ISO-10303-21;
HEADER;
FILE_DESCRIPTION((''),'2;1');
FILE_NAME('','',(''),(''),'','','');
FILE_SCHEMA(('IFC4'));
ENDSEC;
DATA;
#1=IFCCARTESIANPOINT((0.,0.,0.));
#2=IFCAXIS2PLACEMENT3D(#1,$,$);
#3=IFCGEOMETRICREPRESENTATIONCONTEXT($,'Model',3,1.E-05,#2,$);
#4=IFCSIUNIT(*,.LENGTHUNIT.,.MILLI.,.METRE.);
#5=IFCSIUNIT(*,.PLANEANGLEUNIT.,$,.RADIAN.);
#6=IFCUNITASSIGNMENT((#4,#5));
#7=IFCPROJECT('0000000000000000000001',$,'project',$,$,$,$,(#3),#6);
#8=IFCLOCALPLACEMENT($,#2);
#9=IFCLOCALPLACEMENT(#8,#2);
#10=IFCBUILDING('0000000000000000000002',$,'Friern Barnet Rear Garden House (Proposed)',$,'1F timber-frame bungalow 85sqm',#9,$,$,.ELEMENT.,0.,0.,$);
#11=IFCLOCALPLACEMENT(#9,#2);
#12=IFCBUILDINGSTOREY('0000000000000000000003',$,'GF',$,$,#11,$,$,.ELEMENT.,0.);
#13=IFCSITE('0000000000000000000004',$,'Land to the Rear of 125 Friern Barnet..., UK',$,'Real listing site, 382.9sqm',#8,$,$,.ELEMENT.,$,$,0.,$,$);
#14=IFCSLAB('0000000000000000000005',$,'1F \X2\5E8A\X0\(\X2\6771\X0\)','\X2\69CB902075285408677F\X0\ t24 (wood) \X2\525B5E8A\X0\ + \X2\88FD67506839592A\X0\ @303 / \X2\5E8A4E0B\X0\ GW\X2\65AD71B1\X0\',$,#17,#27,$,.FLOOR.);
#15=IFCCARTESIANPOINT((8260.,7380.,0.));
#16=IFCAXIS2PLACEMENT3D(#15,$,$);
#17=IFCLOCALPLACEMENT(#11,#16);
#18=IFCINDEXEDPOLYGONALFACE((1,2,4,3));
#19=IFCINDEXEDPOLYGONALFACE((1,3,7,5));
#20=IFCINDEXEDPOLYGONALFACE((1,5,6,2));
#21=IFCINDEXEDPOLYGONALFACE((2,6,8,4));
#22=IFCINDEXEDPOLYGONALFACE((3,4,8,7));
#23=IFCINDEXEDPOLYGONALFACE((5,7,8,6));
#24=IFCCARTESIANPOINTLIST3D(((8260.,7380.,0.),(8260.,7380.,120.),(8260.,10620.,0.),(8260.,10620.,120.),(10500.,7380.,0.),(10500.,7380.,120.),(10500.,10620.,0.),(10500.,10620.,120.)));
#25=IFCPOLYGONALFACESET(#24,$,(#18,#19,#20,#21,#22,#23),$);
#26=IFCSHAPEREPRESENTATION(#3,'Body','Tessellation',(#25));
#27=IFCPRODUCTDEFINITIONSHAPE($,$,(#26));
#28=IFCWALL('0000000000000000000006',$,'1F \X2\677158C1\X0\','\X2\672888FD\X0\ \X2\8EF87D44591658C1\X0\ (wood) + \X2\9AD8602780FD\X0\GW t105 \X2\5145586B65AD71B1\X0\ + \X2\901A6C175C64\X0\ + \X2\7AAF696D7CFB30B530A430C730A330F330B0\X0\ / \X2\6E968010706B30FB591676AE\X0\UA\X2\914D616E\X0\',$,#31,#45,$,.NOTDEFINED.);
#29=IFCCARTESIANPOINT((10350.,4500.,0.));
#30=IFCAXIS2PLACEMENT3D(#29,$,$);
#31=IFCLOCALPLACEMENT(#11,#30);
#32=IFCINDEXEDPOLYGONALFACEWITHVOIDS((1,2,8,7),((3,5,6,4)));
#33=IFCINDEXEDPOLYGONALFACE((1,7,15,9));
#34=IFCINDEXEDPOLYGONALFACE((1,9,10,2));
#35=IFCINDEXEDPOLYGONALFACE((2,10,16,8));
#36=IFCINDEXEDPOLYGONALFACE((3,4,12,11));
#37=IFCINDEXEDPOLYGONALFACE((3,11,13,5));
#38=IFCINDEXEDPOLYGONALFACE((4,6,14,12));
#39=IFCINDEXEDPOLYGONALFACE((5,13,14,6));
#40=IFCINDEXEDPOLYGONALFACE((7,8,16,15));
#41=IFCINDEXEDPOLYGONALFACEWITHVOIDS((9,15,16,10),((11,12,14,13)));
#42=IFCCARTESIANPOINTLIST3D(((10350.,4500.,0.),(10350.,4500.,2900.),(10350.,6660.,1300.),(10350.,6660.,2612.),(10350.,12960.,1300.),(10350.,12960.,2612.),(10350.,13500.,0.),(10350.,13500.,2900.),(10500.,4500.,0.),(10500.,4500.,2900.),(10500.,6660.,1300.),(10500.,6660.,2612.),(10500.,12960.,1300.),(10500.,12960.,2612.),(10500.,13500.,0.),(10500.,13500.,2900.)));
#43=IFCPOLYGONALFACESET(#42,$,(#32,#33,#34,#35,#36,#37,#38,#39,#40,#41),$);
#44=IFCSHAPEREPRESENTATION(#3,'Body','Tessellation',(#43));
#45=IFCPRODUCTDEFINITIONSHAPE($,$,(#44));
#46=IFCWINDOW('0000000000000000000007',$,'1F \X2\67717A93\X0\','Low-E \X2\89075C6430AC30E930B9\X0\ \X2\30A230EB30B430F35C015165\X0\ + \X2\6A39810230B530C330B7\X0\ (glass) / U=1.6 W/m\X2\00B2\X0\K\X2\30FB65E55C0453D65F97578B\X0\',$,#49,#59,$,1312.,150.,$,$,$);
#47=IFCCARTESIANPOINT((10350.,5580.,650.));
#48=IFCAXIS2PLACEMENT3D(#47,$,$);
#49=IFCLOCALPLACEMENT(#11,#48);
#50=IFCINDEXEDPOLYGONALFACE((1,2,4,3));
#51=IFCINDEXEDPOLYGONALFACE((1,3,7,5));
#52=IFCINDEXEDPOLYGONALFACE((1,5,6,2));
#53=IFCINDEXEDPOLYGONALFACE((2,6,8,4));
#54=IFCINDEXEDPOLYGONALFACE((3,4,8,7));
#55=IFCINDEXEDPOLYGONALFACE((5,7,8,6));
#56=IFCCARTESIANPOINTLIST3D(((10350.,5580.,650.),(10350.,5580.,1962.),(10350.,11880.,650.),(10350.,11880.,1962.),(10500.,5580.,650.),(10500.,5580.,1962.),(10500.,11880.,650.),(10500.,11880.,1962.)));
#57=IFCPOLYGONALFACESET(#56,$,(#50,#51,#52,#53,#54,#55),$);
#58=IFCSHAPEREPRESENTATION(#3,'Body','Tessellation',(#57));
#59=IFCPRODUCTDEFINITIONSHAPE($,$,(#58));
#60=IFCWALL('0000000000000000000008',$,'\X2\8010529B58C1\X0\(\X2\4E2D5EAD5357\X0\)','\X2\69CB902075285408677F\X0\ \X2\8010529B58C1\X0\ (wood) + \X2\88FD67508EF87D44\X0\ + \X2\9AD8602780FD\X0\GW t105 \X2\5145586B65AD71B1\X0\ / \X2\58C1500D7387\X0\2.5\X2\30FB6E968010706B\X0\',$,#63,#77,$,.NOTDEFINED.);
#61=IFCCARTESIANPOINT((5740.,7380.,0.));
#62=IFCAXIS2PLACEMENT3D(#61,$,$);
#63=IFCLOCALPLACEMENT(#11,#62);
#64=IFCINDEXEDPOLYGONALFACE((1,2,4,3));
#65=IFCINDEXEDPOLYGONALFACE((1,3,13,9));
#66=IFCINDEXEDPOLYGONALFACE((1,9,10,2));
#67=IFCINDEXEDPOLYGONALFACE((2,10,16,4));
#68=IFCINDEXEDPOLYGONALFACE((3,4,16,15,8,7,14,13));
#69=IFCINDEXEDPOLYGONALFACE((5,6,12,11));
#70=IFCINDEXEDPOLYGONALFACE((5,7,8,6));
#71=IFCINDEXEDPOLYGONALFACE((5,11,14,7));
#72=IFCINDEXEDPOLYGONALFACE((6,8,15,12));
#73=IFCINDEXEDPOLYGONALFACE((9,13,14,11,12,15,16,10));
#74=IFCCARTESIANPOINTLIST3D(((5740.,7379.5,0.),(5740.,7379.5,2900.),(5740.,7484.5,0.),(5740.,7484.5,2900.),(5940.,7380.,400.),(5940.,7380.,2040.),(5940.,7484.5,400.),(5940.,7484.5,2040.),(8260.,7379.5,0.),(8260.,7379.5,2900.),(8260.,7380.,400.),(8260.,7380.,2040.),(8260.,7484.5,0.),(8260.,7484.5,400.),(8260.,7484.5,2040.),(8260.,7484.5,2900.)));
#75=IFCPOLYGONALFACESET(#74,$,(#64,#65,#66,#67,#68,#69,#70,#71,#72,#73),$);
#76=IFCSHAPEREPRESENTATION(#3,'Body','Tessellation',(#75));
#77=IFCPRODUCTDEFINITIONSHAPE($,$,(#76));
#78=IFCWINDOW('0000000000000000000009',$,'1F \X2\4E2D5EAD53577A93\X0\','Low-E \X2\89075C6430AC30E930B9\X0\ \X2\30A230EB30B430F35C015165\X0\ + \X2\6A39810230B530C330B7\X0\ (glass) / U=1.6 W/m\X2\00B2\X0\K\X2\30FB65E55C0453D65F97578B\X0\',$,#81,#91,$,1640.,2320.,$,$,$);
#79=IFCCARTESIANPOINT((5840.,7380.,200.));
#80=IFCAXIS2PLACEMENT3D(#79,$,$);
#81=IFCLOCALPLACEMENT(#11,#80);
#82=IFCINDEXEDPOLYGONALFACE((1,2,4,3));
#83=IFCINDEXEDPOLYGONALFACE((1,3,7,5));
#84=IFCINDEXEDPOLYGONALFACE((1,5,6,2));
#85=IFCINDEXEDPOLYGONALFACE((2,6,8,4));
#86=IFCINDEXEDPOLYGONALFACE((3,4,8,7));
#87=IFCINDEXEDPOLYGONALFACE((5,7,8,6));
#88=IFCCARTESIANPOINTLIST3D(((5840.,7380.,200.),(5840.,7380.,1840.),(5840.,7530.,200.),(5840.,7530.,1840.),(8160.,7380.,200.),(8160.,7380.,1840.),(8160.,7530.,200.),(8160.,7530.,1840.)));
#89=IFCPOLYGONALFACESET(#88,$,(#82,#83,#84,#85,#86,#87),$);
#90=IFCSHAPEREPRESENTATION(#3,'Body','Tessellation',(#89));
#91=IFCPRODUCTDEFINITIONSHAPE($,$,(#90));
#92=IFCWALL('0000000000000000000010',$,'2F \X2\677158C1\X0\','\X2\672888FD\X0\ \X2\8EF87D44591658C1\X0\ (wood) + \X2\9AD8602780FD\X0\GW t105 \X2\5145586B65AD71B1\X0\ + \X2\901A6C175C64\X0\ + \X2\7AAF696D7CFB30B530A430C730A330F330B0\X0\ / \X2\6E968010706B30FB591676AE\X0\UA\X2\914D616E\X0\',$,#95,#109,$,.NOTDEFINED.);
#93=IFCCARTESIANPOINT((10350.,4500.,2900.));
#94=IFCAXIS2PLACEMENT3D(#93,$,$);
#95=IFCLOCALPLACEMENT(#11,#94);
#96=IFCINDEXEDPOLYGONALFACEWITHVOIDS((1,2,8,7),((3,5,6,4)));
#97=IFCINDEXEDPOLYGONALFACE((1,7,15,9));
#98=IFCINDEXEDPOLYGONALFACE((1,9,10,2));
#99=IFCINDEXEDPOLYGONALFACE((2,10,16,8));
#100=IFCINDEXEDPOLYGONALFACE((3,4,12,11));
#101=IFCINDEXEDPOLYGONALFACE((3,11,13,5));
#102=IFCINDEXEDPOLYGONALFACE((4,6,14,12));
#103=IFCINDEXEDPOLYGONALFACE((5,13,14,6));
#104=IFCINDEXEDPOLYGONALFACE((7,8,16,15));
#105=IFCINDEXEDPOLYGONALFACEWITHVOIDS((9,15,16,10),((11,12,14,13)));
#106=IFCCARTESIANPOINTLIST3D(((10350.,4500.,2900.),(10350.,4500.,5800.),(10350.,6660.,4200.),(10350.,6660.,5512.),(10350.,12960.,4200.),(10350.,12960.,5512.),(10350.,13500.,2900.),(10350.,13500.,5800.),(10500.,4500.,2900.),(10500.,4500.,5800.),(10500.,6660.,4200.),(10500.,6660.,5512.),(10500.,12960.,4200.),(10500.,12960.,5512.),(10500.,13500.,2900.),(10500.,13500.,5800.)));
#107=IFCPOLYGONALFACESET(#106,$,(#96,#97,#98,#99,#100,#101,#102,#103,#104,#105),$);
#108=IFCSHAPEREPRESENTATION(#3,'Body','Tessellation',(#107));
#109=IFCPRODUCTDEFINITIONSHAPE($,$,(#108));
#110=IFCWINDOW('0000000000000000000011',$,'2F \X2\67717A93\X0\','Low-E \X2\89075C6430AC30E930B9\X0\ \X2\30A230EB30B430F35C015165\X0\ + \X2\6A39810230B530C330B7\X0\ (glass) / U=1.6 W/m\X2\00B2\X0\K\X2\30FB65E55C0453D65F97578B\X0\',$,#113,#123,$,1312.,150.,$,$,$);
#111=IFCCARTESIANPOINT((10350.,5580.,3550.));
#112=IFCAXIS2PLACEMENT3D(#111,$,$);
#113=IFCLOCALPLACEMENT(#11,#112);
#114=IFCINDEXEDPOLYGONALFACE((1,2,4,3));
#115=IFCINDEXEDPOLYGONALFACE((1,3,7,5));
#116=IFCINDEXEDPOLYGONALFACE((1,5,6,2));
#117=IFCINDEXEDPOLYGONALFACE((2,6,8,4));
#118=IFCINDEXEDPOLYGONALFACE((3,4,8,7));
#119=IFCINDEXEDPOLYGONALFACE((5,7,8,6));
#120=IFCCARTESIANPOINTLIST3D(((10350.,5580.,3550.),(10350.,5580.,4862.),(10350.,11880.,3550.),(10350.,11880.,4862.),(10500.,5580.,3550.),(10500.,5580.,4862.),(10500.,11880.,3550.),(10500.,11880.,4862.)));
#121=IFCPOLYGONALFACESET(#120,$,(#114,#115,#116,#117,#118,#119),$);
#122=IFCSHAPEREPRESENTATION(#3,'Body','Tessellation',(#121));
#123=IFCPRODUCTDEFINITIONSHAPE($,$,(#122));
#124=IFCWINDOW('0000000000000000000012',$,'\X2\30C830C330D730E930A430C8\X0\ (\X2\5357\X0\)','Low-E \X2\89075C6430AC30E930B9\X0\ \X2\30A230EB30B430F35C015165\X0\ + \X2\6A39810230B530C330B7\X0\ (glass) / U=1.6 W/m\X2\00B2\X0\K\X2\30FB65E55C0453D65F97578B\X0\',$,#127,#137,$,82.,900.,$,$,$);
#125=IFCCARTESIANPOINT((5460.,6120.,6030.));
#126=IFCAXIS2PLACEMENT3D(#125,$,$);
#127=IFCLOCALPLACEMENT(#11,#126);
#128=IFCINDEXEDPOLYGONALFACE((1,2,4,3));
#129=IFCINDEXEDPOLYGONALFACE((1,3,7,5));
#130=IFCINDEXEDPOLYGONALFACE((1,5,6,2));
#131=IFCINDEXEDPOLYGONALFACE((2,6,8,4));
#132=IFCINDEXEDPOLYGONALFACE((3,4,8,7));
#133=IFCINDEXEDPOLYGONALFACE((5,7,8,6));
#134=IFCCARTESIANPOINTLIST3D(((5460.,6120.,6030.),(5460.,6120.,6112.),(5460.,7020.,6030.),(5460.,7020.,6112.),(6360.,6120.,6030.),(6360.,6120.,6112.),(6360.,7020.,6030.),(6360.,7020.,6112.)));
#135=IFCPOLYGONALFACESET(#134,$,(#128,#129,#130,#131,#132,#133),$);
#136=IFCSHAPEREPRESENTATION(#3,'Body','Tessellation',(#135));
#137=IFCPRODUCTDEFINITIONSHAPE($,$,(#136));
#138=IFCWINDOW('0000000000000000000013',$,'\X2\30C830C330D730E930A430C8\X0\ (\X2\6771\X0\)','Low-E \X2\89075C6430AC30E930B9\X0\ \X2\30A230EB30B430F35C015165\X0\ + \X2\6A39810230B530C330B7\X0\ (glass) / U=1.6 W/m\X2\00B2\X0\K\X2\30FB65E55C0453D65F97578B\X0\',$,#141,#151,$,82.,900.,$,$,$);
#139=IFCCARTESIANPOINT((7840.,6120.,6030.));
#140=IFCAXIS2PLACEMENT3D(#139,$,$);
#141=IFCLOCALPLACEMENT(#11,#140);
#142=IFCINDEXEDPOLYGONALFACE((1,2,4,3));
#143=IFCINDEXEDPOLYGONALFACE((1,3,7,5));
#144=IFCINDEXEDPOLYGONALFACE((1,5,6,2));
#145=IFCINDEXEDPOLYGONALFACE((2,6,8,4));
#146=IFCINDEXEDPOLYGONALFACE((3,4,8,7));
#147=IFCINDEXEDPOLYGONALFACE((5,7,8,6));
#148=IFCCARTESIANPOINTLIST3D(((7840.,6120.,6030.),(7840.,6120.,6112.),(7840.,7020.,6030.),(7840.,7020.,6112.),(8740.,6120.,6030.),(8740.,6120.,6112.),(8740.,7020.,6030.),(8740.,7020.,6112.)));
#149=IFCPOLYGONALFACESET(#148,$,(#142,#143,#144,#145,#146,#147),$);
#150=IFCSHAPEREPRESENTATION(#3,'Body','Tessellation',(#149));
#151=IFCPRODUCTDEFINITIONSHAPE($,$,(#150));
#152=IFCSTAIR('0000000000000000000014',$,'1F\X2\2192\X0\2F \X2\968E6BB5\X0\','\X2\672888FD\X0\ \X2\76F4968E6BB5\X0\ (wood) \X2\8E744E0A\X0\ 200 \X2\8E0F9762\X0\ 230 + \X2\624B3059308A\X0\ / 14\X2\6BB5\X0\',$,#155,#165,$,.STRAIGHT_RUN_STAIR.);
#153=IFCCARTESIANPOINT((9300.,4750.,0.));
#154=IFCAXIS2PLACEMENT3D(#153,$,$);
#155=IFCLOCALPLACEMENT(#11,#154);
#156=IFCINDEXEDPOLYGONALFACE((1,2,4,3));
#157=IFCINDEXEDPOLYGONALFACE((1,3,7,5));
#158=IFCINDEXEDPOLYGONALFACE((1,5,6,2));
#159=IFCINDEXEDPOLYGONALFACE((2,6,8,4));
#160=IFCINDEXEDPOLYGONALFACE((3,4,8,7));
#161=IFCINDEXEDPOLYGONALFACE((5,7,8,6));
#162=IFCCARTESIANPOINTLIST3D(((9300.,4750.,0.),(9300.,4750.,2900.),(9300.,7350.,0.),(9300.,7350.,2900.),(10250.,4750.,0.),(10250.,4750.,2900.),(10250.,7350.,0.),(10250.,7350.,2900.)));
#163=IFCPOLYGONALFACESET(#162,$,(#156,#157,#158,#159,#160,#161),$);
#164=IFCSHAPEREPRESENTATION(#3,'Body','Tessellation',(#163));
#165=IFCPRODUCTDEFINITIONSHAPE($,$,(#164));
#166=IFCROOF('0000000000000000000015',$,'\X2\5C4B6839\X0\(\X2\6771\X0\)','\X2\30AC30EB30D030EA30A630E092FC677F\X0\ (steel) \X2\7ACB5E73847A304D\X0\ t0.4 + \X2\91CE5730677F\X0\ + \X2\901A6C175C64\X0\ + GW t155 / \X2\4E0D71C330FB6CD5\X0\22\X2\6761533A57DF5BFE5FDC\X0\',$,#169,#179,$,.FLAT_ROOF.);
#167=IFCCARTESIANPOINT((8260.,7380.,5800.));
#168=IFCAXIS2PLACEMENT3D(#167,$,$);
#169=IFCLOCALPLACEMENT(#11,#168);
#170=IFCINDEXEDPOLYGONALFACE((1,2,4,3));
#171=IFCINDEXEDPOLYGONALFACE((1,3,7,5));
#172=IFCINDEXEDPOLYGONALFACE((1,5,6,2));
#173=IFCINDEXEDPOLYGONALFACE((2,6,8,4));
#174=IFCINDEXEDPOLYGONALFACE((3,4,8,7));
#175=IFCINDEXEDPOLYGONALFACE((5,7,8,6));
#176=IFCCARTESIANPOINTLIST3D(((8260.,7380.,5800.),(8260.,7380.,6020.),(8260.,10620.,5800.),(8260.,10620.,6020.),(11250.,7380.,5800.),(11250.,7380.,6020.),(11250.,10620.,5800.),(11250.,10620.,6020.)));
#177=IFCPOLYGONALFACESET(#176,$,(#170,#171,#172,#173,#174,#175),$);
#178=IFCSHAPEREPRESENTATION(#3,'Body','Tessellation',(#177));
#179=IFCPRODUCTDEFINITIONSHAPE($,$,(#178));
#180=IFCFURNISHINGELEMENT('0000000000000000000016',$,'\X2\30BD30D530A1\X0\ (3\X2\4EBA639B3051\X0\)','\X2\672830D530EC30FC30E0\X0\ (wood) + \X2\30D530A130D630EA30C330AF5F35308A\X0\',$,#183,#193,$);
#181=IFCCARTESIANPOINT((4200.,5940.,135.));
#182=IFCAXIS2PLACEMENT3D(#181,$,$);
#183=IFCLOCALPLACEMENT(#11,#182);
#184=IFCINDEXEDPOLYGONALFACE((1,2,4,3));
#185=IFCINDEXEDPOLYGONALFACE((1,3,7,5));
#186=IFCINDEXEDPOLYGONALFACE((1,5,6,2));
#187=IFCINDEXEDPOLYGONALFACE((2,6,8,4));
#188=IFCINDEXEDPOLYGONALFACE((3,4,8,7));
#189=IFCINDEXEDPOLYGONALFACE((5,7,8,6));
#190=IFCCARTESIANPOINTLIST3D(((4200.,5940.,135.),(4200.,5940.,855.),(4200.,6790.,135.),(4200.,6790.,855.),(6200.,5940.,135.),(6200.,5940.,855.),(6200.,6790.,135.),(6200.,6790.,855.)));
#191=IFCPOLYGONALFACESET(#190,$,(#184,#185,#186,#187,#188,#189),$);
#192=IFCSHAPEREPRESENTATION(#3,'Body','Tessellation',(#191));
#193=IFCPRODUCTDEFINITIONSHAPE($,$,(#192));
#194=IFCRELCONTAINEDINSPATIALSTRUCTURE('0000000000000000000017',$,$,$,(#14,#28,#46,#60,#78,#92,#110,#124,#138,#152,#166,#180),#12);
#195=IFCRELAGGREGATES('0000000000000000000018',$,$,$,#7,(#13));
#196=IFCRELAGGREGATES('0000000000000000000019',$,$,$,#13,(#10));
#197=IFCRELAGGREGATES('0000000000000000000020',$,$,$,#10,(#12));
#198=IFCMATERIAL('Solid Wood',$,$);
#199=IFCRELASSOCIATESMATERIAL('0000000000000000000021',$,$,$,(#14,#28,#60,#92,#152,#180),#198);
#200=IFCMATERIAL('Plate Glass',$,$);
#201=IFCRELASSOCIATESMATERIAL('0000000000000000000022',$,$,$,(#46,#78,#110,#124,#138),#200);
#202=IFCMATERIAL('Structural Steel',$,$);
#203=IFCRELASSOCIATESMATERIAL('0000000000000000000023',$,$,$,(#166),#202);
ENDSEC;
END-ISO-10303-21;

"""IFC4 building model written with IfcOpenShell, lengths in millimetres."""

from ifc_helpers import new_model, si_unit, frame, frame_2d, origin, place, context, project, spatial, rectangle, extrude, material, element, fill, save


model = new_model("IFC4")

# Units and contexts
model_context = context("Model", 3, precision=1e-05, world=origin())
ifc_project = project(units=[si_unit("LENGTHUNIT", "METRE", prefix="MILLI"), si_unit("PLANEANGLEUNIT", "RADIAN")], contexts=[model_context])

# Site, building, storey
site_placement = place(None, origin())
site = spatial("IfcSite", under=ifc_project, at=site_placement, Name="Land to the Rear of 125 Friern Barnet..., UK", ObjectType="Real listing site, 382.9sqm", CompositionType="ELEMENT", RefElevation=0.0)
building_placement = place(site_placement, origin())
building = spatial("IfcBuilding", under=site, at=building_placement, Name="Friern Barnet Rear Garden House (Proposed)", ObjectType="1F timber-frame bungalow 85sqm", CompositionType="ELEMENT", ElevationOfRefHeight=0.0, ElevationOfTerrain=0.0)
storey_placement = place(building_placement, origin())
storey = spatial("IfcBuildingStorey", under=building, at=storey_placement, Name="GF", CompositionType="ELEMENT", Elevation=0.0)

# Slab
ifc_material_1 = material(Name="Solid Wood")
slab_placement = place(storey_placement, frame((8260.0, 7380.0, 0.0)))
element("IfcSlab", 1, at=slab_placement, inside=storey, material=ifc_material_1, Name="1F 床(東)", Description="構造用合板 t24 (wood) 剛床 + 製材根太 @303 / 床下 GW断熱", PredefinedType="FLOOR", context=model_context, shape_type="SweptSolid", body=[
    extrude(rectangle(XDim=2240.0, YDim=3240.0, at=frame_2d((1120.0, 1620.0))), frame((8260.0, 7380.0, 0.0)), (0.0, 0.0, 1.0), 120.0),
])

# Walls, openings, windows
wall_1_placement = place(storey_placement, frame((10350.0, 4500.0, 0.0)))
wall_1 = element("IfcWall", 2, at=wall_1_placement, inside=storey, material=ifc_material_1, Name="1F 東壁", Description="木製 軸組外壁 (wood) + 高性能GW t105 充填断熱 + 通気層 + 窯業系サイディング / 準耐火・外皮UA配慮", PredefinedType="NOTDEFINED", context=model_context, shape_type="SweptSolid", body=[
    extrude(rectangle(XDim=150.0, YDim=9000.0, at=frame_2d((75.0, 4500.0))), frame((10350.0, 4500.0, 0.0)), (0.0, 0.0, 1.0), 2900.0),
])
opening_1_placement = place(storey_placement, frame((10350.0, 5580.0, 650.0)))
opening_1 = element("IfcOpeningElement", 3, at=opening_1_placement, cuts=wall_1, PredefinedType="NOTDEFINED", context=model_context, shape_type="SweptSolid", body=[
    extrude(rectangle(XDim=150.0, YDim=6300.0, at=frame_2d((75.0, 3150.0))), frame((10350.0, 5580.0, 650.0)), (0.0, 0.0, 1.0), 1312.0),
])
ifc_material_2 = material(Name="Plate Glass")
window_1_placement = place(storey_placement, frame((10350.0, 5580.0, 650.0)))
window_1 = element("IfcWindow", 4, at=window_1_placement, inside=storey, material=ifc_material_2, Name="1F 東窓", Description="Low-E 複層ガラス アルゴン封入 + 樹脂サッシ (glass) / U=1.6 W/m²K・日射取得型", OverallHeight=1312.0, OverallWidth=150.0, context=model_context, shape_type="SweptSolid", body=[
    extrude(rectangle(XDim=150.0, YDim=6300.0, at=frame_2d((75.0, 3150.0))), frame((10350.0, 5580.0, 650.0)), (0.0, 0.0, 1.0), 1312.0),
])
fill(opening_1, window_1)
wall_2_placement = place(storey_placement, frame((5740.0, 7380.0, 0.0)))
wall_2 = element("IfcWall", 5, at=wall_2_placement, inside=storey, material=ifc_material_1, Name="耐力壁(中庭南)", Description="構造用合板 耐力壁 (wood) + 製材軸組 + 高性能GW t105 充填断熱 / 壁倍率2.5・準耐火", PredefinedType="NOTDEFINED", context=model_context, shape_type="SweptSolid", body=[
    extrude(rectangle(XDim=2520.0, YDim=105.0, at=frame_2d((1260.0, 52.0))), frame((5740.0, 7380.0, 0.0)), (0.0, 0.0, 1.0), 2900.0),
])
opening_2_placement = place(storey_placement, frame((5840.0, 7380.0, 200.0)))
opening_2 = element("IfcOpeningElement", 6, at=opening_2_placement, cuts=wall_2, PredefinedType="NOTDEFINED", context=model_context, shape_type="SweptSolid", body=[
    extrude(rectangle(XDim=2320.0, YDim=150.0, at=frame_2d((1160.0, 75.0))), frame((5840.0, 7380.0, 200.0)), (0.0, 0.0, 1.0), 1640.0),
])
window_2_placement = place(storey_placement, frame((5840.0, 7380.0, 200.0)))
window_2 = element("IfcWindow", 7, at=window_2_placement, inside=storey, material=ifc_material_2, Name="1F 中庭南窓", Description="Low-E 複層ガラス アルゴン封入 + 樹脂サッシ (glass) / U=1.6 W/m²K・日射取得型", OverallHeight=1640.0, OverallWidth=2320.0, context=model_context, shape_type="SweptSolid", body=[
    extrude(rectangle(XDim=2320.0, YDim=150.0, at=frame_2d((1160.0, 75.0))), frame((5840.0, 7380.0, 200.0)), (0.0, 0.0, 1.0), 1640.0),
])
fill(opening_2, window_2)

# Wall, opening, window
wall_3_placement = place(storey_placement, frame((10350.0, 4500.0, 2900.0)))
wall_3 = element("IfcWall", 8, at=wall_3_placement, inside=storey, material=ifc_material_1, Name="2F 東壁", Description="木製 軸組外壁 (wood) + 高性能GW t105 充填断熱 + 通気層 + 窯業系サイディング / 準耐火・外皮UA配慮", PredefinedType="NOTDEFINED", context=model_context, shape_type="SweptSolid", body=[
    extrude(rectangle(XDim=150.0, YDim=9000.0, at=frame_2d((75.0, 4500.0))), frame((10350.0, 4500.0, 2900.0)), (0.0, 0.0, 1.0), 2900.0),
])
opening_3_placement = place(storey_placement, frame((10350.0, 5580.0, 3550.0)))
opening_3 = element("IfcOpeningElement", 9, at=opening_3_placement, cuts=wall_3, PredefinedType="NOTDEFINED", context=model_context, shape_type="SweptSolid", body=[
    extrude(rectangle(XDim=150.0, YDim=6300.0, at=frame_2d((75.0, 3150.0))), frame((10350.0, 5580.0, 3550.0)), (0.0, 0.0, 1.0), 1312.0),
])
window_3_placement = place(storey_placement, frame((10350.0, 5580.0, 3550.0)))
window_3 = element("IfcWindow", 10, at=window_3_placement, inside=storey, material=ifc_material_2, Name="2F 東窓", Description="Low-E 複層ガラス アルゴン封入 + 樹脂サッシ (glass) / U=1.6 W/m²K・日射取得型", OverallHeight=1312.0, OverallWidth=150.0, context=model_context, shape_type="SweptSolid", body=[
    extrude(rectangle(XDim=150.0, YDim=6300.0, at=frame_2d((75.0, 3150.0))), frame((10350.0, 5580.0, 3550.0)), (0.0, 0.0, 1.0), 1312.0),
])
fill(opening_3, window_3)

# Windows
window_4_placement = place(storey_placement, frame((5460.0, 6120.0, 6030.0)))
element("IfcWindow", 11, at=window_4_placement, inside=storey, material=ifc_material_2, Name="トップライト (南)", Description="Low-E 複層ガラス アルゴン封入 + 樹脂サッシ (glass) / U=1.6 W/m²K・日射取得型", OverallHeight=82.0, OverallWidth=900.0, context=model_context, shape_type="SweptSolid", body=[
    extrude(rectangle(XDim=900.0, YDim=900.0, at=frame_2d((450.0, 450.0))), frame((5460.0, 6120.0, 6030.0)), (0.0, 0.0, 1.0), 82.0),
])
window_5_placement = place(storey_placement, frame((7840.0, 6120.0, 6030.0)))
element("IfcWindow", 12, at=window_5_placement, inside=storey, material=ifc_material_2, Name="トップライト (東)", Description="Low-E 複層ガラス アルゴン封入 + 樹脂サッシ (glass) / U=1.6 W/m²K・日射取得型", OverallHeight=82.0, OverallWidth=900.0, context=model_context, shape_type="SweptSolid", body=[
    extrude(rectangle(XDim=900.0, YDim=900.0, at=frame_2d((450.0, 450.0))), frame((7840.0, 6120.0, 6030.0)), (0.0, 0.0, 1.0), 82.0),
])

# Stair
stair_placement = place(storey_placement, frame((9300.0, 4750.0, 0.0)))
element("IfcStair", 13, at=stair_placement, inside=storey, material=ifc_material_1, Name="1F→2F 階段", Description="木製 直階段 (wood) 蹴上 200 踏面 230 + 手すり / 14段", PredefinedType="STRAIGHT_RUN_STAIR", context=model_context, shape_type="SweptSolid", body=[
    extrude(rectangle(XDim=950.0, YDim=2600.0, at=frame_2d((475.0, 1300.0))), frame((9300.0, 4750.0, 0.0)), (0.0, 0.0, 1.0), 2900.0),
])

# Roof
ifc_material_3 = material(Name="Structural Steel")
roof_placement = place(storey_placement, frame((8260.0, 7380.0, 5800.0)))
element("IfcRoof", 14, at=roof_placement, inside=storey, material=ifc_material_3, Name="屋根(東)", Description="ガルバリウム鋼板 (steel) 立平葺き t0.4 + 野地板 + 通気層 + GW t155 / 不燃・法22条区域対応", PredefinedType="FLAT_ROOF", context=model_context, shape_type="SweptSolid", body=[
    extrude(rectangle(XDim=2990.0, YDim=3240.0, at=frame_2d((1495.0, 1620.0))), frame((8260.0, 7380.0, 5800.0)), (0.0, 0.0, 1.0), 220.0),
])

# Furnishing element
furnishing_1_placement = place(storey_placement, frame((4200.0, 5940.0, 135.0)))
element("IfcFurnishingElement", 15, at=furnishing_1_placement, inside=storey, material=ifc_material_1, Name="ソファ (3人掛け)", Description="木フレーム (wood) + ファブリック張り", context=model_context, shape_type="SweptSolid", body=[
    extrude(rectangle(XDim=2000.0, YDim=850.0, at=frame_2d((1000.0, 425.0))), frame((4200.0, 5940.0, 135.0)), (0.0, 0.0, 1.0), 720.0),
])

save(model, "model.ifc")
